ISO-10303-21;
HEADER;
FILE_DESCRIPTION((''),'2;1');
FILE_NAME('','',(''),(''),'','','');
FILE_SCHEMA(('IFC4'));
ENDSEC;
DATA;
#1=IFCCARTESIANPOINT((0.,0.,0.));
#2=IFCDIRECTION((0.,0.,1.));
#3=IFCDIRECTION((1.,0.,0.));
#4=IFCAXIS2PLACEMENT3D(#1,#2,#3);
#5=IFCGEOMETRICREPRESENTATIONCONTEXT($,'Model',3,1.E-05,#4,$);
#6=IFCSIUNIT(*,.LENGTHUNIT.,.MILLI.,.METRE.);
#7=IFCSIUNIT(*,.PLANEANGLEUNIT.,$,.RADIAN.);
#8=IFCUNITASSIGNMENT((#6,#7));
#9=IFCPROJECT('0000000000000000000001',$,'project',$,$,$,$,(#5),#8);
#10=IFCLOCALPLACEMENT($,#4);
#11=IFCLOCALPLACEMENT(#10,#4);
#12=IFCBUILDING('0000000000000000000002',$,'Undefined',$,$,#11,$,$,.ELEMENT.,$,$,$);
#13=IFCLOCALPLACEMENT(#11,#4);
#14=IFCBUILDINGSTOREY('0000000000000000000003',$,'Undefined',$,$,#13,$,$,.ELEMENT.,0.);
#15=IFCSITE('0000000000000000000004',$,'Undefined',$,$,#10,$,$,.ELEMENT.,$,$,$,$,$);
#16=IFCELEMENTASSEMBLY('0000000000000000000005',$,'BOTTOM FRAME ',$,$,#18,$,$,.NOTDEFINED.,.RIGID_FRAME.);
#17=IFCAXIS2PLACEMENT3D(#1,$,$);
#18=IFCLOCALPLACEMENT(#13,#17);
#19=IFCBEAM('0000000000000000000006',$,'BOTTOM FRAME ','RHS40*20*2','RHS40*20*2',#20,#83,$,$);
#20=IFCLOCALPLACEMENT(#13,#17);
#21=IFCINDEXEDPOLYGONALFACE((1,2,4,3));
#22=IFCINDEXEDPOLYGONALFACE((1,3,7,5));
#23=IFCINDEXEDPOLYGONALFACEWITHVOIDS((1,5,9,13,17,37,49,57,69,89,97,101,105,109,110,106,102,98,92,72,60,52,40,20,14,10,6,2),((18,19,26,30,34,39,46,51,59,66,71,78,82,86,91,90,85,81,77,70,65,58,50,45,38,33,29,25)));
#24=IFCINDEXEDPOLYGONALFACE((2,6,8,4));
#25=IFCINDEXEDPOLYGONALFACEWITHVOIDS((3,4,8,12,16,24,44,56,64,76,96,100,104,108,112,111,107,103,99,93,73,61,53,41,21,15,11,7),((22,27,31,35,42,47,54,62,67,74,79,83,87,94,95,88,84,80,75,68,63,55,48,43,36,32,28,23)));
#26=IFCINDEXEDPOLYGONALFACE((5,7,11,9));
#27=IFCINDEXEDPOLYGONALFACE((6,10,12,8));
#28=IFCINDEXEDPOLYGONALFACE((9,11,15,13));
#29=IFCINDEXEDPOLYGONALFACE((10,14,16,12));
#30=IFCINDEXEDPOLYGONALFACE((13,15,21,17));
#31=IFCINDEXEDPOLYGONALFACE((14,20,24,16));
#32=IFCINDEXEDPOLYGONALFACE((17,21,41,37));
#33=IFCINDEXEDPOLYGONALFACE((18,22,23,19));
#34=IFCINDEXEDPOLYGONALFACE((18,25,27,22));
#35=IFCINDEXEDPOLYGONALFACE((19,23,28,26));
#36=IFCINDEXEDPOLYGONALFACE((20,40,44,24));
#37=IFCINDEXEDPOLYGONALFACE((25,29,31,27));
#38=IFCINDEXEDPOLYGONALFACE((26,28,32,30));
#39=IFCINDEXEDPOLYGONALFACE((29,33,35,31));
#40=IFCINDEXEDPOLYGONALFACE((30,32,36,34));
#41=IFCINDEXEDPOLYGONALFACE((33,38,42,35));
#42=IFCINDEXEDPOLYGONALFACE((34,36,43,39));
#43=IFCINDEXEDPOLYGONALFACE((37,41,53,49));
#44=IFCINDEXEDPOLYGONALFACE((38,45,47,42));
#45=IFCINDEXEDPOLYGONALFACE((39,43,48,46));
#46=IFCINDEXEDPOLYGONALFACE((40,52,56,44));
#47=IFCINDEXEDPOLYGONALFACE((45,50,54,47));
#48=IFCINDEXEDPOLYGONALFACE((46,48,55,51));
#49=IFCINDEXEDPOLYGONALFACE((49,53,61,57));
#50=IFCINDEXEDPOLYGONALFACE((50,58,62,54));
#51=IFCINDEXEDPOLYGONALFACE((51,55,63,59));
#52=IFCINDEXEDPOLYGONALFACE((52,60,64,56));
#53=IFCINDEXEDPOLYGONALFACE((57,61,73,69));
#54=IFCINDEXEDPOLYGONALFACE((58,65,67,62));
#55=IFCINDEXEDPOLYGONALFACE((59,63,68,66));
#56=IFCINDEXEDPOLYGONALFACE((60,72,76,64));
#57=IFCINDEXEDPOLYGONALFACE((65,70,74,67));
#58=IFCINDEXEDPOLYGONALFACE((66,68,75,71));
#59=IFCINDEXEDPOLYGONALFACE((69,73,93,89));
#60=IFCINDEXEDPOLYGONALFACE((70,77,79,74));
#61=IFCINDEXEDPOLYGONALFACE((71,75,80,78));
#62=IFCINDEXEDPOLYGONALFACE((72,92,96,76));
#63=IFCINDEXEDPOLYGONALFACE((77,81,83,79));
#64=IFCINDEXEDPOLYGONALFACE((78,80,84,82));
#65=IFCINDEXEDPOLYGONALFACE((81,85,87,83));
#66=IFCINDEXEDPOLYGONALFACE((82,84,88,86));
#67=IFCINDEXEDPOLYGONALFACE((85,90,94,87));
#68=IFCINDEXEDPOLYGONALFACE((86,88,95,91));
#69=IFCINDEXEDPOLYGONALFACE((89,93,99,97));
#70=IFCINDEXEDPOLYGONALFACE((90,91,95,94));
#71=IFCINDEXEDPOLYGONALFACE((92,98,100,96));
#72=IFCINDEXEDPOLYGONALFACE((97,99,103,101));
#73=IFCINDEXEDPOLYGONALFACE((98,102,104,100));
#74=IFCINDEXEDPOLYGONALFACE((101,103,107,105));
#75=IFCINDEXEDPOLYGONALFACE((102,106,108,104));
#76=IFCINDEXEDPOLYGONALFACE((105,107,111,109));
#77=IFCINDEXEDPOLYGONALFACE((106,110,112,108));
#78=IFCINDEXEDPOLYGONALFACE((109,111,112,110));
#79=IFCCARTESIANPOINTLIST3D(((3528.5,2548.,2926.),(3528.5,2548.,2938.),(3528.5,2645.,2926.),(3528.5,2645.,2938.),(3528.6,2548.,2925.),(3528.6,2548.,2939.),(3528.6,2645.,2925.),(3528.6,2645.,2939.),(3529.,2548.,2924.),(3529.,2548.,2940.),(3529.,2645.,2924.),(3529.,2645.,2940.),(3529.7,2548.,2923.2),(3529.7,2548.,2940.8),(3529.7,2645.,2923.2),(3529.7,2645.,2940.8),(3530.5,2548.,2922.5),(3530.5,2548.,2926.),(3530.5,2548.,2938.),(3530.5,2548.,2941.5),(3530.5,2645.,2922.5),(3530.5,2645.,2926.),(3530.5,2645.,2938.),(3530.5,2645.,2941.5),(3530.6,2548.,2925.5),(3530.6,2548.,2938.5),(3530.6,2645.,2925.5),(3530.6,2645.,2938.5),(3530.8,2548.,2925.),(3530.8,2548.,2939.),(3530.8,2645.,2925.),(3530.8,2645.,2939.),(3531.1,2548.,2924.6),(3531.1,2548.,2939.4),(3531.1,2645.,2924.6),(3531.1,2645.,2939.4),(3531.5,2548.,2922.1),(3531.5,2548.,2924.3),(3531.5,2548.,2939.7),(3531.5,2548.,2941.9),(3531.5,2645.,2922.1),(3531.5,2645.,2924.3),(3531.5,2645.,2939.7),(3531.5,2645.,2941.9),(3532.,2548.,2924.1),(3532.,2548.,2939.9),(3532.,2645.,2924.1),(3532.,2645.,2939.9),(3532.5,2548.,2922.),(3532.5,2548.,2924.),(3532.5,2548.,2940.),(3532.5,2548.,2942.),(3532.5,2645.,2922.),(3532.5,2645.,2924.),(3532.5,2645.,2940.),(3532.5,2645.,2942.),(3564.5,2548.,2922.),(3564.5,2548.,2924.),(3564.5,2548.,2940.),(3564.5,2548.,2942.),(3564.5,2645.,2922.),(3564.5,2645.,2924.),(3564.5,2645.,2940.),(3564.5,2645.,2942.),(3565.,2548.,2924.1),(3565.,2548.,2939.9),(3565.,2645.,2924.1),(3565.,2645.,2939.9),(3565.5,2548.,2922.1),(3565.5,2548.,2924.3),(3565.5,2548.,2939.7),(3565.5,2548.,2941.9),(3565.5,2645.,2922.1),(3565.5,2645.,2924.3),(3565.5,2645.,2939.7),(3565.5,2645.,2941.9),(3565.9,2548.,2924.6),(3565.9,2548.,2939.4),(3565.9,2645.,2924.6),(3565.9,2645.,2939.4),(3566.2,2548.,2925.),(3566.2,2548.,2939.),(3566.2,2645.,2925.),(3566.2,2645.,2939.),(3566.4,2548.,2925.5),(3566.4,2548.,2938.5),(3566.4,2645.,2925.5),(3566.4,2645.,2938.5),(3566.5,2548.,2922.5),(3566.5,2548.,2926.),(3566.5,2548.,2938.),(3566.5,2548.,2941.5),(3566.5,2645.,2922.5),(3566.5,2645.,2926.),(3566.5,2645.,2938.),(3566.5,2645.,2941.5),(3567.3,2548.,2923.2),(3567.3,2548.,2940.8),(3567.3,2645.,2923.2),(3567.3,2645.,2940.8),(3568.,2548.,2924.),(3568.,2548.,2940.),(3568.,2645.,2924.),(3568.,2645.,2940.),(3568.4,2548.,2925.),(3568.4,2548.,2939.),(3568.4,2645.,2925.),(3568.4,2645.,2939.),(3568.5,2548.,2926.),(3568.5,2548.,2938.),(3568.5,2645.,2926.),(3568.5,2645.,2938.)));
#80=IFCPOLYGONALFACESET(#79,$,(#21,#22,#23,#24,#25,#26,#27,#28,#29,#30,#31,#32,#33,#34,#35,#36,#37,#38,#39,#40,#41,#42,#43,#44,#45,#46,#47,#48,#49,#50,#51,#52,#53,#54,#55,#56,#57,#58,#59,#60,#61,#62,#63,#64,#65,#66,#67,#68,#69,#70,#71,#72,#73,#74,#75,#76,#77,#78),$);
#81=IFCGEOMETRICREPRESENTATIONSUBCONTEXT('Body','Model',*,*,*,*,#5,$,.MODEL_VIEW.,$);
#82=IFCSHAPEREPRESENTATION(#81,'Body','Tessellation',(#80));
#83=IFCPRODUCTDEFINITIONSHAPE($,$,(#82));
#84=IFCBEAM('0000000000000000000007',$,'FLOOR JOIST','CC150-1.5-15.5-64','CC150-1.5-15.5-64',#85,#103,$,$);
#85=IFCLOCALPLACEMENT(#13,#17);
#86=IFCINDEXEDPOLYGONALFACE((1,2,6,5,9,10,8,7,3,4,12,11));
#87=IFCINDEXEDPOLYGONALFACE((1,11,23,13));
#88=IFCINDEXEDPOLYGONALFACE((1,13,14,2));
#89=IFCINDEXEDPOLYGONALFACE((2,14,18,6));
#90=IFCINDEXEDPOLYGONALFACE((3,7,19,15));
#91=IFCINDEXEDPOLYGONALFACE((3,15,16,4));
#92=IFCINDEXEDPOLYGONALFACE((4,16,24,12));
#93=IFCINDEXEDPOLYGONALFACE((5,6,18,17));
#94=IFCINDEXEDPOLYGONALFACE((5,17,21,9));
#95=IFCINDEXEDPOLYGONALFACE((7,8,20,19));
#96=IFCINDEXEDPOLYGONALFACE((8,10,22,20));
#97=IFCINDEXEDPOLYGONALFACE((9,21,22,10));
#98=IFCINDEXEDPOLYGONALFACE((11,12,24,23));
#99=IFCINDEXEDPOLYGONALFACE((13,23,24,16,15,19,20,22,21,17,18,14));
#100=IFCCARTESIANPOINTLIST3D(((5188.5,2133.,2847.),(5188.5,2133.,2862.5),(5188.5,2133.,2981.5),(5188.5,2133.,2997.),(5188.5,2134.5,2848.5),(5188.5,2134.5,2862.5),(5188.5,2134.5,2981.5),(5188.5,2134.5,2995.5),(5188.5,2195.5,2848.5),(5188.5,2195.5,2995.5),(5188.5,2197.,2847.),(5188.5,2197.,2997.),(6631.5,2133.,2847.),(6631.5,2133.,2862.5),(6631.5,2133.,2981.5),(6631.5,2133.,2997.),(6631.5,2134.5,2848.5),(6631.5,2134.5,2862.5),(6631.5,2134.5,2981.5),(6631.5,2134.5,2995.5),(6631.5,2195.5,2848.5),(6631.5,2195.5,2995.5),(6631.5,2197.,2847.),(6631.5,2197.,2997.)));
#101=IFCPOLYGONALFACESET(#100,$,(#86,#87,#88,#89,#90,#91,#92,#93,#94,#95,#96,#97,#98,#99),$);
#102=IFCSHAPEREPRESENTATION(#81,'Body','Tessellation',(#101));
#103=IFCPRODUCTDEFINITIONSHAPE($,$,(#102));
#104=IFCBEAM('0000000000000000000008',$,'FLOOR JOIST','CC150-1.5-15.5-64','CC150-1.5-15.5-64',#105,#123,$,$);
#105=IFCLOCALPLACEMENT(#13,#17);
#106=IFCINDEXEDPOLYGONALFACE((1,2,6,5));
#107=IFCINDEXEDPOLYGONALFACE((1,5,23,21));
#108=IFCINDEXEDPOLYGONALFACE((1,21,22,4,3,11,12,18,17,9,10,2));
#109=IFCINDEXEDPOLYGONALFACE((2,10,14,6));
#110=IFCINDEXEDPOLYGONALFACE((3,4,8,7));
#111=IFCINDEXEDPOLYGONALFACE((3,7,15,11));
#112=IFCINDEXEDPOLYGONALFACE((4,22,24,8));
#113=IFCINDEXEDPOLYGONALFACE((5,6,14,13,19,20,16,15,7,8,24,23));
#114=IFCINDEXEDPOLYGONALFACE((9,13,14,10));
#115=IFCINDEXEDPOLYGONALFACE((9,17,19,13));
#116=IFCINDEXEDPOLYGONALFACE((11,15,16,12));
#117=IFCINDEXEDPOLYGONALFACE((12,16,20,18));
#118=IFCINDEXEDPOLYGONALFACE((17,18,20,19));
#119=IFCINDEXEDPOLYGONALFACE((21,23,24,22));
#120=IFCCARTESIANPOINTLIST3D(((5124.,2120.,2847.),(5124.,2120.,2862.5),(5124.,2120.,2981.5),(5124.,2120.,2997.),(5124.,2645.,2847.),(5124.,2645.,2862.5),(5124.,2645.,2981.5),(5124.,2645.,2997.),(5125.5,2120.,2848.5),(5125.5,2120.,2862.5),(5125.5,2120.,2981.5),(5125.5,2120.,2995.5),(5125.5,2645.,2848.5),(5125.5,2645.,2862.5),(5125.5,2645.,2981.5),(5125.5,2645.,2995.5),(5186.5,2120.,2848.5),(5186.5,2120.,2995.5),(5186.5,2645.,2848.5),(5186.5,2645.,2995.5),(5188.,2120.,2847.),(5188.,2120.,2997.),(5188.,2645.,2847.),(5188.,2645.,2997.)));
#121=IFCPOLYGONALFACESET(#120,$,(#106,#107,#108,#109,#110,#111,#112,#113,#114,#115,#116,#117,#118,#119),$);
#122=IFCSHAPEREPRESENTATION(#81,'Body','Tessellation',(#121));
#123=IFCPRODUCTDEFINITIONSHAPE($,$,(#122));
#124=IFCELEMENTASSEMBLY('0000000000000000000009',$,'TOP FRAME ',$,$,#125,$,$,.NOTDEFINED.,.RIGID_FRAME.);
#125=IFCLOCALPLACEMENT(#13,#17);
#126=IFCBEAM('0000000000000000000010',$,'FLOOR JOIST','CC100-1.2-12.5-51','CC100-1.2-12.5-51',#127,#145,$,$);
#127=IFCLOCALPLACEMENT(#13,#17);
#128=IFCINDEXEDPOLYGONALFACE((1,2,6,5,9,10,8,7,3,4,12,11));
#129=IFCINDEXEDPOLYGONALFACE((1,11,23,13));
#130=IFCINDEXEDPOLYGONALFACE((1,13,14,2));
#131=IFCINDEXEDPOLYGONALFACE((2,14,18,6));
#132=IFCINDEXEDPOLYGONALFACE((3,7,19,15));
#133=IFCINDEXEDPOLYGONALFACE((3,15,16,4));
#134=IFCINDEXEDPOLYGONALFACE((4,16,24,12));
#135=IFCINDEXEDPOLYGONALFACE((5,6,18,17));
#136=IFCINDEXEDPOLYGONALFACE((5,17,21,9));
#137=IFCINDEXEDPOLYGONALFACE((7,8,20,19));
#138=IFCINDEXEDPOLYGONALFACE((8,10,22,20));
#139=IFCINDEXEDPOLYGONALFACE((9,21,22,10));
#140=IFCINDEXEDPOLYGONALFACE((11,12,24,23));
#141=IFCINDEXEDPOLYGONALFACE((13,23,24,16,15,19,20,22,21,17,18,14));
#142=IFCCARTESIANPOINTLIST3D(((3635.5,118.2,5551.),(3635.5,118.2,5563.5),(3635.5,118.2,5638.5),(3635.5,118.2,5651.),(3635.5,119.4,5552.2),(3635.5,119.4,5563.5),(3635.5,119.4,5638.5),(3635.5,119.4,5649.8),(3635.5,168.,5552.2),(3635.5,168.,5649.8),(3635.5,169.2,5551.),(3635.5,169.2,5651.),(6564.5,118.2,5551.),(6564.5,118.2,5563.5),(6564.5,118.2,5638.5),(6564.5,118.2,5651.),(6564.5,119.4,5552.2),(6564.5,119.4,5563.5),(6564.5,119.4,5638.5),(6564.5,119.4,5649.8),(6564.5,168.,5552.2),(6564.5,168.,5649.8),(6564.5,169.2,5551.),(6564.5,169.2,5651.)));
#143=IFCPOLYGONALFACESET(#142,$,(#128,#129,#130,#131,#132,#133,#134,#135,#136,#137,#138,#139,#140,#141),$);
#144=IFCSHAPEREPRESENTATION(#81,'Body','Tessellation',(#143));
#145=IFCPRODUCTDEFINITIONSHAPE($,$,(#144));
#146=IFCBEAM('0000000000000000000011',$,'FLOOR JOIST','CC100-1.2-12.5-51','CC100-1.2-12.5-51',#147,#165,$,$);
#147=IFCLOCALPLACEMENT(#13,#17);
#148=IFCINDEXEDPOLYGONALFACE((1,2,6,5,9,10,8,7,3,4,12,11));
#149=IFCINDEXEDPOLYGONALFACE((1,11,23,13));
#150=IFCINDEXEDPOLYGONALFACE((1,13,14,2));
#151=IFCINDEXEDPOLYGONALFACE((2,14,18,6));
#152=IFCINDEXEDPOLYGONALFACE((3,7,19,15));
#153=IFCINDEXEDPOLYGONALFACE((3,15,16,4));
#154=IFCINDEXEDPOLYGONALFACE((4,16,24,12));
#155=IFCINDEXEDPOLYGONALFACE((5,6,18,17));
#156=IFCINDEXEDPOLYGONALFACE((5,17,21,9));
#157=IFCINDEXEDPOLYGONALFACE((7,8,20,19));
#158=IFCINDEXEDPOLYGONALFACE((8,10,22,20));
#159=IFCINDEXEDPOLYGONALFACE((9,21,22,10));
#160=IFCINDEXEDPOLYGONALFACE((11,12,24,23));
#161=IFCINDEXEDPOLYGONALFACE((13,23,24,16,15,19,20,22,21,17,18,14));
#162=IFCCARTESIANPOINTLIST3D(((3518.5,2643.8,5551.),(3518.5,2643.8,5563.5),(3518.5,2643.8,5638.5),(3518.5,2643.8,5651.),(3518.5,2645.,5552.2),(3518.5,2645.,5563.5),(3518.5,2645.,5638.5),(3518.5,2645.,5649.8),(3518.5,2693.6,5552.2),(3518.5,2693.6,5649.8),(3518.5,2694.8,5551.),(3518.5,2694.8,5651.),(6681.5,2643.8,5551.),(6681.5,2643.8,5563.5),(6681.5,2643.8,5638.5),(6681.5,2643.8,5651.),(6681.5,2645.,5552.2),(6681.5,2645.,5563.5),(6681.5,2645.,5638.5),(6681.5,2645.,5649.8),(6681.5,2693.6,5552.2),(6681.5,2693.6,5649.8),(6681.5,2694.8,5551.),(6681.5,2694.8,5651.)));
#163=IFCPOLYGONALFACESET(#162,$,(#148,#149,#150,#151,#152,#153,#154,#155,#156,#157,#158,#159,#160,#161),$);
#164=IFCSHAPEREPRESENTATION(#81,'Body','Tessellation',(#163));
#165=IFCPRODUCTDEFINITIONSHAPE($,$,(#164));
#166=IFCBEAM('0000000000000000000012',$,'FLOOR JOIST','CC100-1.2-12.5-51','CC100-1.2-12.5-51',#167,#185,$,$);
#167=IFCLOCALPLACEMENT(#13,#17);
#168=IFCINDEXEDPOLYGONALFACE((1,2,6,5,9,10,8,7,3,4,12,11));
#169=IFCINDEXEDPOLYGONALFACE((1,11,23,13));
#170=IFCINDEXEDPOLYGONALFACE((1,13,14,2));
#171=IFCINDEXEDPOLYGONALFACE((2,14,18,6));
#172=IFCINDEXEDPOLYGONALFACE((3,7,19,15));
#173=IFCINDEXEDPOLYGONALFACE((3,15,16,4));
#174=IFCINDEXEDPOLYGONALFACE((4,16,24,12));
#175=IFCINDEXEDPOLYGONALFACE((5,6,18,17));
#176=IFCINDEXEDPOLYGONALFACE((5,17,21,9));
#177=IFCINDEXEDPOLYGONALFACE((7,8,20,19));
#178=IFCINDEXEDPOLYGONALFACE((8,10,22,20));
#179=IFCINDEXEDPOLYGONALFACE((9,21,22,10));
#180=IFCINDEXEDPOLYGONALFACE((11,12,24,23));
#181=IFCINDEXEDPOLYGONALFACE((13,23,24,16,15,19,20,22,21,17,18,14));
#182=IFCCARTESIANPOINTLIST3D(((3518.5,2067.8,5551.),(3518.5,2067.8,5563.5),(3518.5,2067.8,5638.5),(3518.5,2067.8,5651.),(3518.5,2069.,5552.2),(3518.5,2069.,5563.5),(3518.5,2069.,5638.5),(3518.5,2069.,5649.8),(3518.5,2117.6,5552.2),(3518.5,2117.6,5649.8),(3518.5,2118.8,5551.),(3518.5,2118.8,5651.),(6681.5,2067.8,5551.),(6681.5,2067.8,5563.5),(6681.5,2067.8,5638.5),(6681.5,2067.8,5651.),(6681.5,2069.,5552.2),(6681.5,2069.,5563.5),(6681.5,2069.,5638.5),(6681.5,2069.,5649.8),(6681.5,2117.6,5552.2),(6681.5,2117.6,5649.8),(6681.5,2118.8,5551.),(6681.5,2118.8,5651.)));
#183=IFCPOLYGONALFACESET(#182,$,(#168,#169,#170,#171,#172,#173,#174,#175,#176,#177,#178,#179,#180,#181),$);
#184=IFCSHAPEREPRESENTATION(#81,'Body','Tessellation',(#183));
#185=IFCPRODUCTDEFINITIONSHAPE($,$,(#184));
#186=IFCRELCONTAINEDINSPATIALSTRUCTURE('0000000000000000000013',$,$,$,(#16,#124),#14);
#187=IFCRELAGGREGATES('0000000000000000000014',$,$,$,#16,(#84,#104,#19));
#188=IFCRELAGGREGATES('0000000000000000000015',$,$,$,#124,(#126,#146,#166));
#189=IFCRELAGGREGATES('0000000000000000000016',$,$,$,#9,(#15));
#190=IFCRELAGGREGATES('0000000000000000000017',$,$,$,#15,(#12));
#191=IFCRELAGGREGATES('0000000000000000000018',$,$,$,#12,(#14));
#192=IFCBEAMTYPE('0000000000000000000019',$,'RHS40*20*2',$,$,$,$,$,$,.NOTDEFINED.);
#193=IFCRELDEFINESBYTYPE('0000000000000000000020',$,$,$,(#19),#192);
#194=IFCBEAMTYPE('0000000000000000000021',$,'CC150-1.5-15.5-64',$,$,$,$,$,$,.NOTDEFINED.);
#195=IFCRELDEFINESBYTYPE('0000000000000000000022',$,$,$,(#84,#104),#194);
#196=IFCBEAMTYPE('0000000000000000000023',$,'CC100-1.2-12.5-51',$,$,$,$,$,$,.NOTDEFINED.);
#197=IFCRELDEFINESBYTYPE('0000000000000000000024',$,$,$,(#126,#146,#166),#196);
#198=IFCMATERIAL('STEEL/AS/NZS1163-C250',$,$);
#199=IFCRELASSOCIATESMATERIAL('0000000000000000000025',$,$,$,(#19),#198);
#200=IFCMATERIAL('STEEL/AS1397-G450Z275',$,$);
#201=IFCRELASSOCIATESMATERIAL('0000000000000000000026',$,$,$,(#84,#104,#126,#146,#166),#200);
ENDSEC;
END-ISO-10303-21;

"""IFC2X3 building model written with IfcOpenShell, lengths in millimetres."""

from ifc_helpers import new_model, si_unit, frame, origin_with_axes, origin_2d_with_axis, place, context, subcontext, project, spatial, hollow_rectangle, c_section, extrude, material, type_object, element, aggregate, save


model = new_model("IFC2X3")

# Units and contexts
model_context = context("Model", 3, precision=1e-05, world=origin_with_axes())
body_context = subcontext(model_context, "Body", "Model", "MODEL_VIEW")
ifc_project = project(units=[si_unit("LENGTHUNIT", "METRE", prefix="MILLI"), si_unit("PLANEANGLEUNIT", "RADIAN")], contexts=[model_context])

# Site, building, storey
site_placement = place(None, origin_with_axes())
site = spatial("IfcSite", under=ifc_project, at=site_placement, Name="Undefined", CompositionType="ELEMENT")
building_placement = place(site_placement, origin_with_axes())
building = spatial("IfcBuilding", under=site, at=building_placement, Name="Undefined", CompositionType="ELEMENT")
storey_placement = place(building_placement, origin_with_axes())
storey = spatial("IfcBuildingStorey", under=building, at=storey_placement, Name="Undefined", CompositionType="ELEMENT", Elevation=0.0)

# Element assemblies, beams
assembly_1_placement = place(storey_placement, origin_with_axes())
assembly_1 = element("IfcElementAssembly", 1, at=assembly_1_placement, inside=storey, Name="BOTTOM FRAME ", AssemblyPlace="NOTDEFINED", PredefinedType="RIGID_FRAME")
ifc_material_1 = material(Name="STEEL/AS1397-G450Z275")
ifc_material_2 = material(Name="STEEL/AS/NZS1163-C250")
beam_type_1 = type_object("IfcBeamType", Name="RHS40*20*2", PredefinedType="NOTDEFINED")
beam_1_placement = place(assembly_1_placement, frame((3548.5, 2645.0, 2932.0), z_axis=(1.0, 0.0, 0.0), x_axis=(0.0, -1.0, 0.0)))
beam_1 = element("IfcBeam", 2, at=beam_1_placement, type_object=beam_type_1, material=ifc_material_2, Name="BOTTOM FRAME ", Description="RHS40*20*2", ObjectType="RHS40*20*2", context=body_context, shape_type="SweptSolid", body=[
    extrude(hollow_rectangle(XDim=20.0, YDim=40.0, WallThickness=2.0, InnerFilletRadius=2.0, OuterFilletRadius=4.0, at=origin_2d_with_axis()), frame((97.0, 0.0, 0.0), z_axis=(-1.0, 0.0, 0.0), x_axis=(0.0, -1.0, 0.0)), (0.0, 0.0, 1.0), 97.0),
])
beam_type_2 = type_object("IfcBeamType", Name="CC150-1.5-15.5-64", PredefinedType="NOTDEFINED")
beam_2_placement = place(assembly_1_placement, frame((5188.5, 2165.0, 2922.0), z_axis=(0.0, 0.0, 1.0), x_axis=(1.0, 0.0, 0.0)))
beam_2 = element("IfcBeam", 3, at=beam_2_placement, type_object=beam_type_2, material=ifc_material_1, Name="FLOOR JOIST", Description="CC150-1.5-15.5-64", ObjectType="CC150-1.5-15.5-64", context=body_context, shape_type="SweptSolid", body=[
    extrude(c_section(Depth=150.0, Width=64.0, WallThickness=1.5, Girth=15.5, at=origin_2d_with_axis()), frame((1443.0, 0.0, 0.0), z_axis=(-1.0, 0.0, 0.0), x_axis=(0.0, -1.0, 0.0)), (0.0, 0.0, 1.0), 1443.0),
])
beam_3_placement = place(assembly_1_placement, frame((5156.0, 2645.0, 2922.0), z_axis=(0.0, 0.0, 1.0), x_axis=(0.0, -1.0, 0.0)))
beam_3 = element("IfcBeam", 4, at=beam_3_placement, type_object=beam_type_2, material=ifc_material_1, Name="FLOOR JOIST", Description="CC150-1.5-15.5-64", ObjectType="CC150-1.5-15.5-64", context=body_context, shape_type="SweptSolid", body=[
    extrude(c_section(Depth=150.0, Width=64.0, WallThickness=1.5, Girth=15.5, at=origin_2d_with_axis()), frame((525.0, 0.0, 0.0), z_axis=(-1.0, 0.0, 0.0), x_axis=(0.0, -1.0, 0.0)), (0.0, 0.0, 1.0), 525.0),
])
assembly_2_placement = place(storey_placement, origin_with_axes())
assembly_2 = element("IfcElementAssembly", 5, at=assembly_2_placement, inside=storey, Name="TOP FRAME ", AssemblyPlace="NOTDEFINED", PredefinedType="RIGID_FRAME")
beam_type_3 = type_object("IfcBeamType", Name="CC100-1.2-12.5-51", PredefinedType="NOTDEFINED")
beam_4_placement = place(assembly_2_placement, frame((3635.5, 143.7, 5601.0), z_axis=(0.0, 0.0, 1.0), x_axis=(1.0, 0.0, 0.0)))
beam_4 = element("IfcBeam", 6, at=beam_4_placement, type_object=beam_type_3, material=ifc_material_1, Name="FLOOR JOIST", Description="CC100-1.2-12.5-51", ObjectType="CC100-1.2-12.5-51", context=body_context, shape_type="SweptSolid", body=[
    extrude(c_section(Depth=100.0, Width=51.0, WallThickness=1.2, Girth=12.5, at=origin_2d_with_axis()), frame((2929.0, 0.0, 0.0), z_axis=(-1.0, 0.0, 0.0), x_axis=(0.0, -1.0, 0.0)), (0.0, 0.0, 1.0), 2929.0),
])
beam_5_placement = place(assembly_2_placement, frame((3518.5, 2669.3, 5601.0), z_axis=(0.0, 0.0, 1.0), x_axis=(1.0, 0.0, 0.0)))
beam_5 = element("IfcBeam", 7, at=beam_5_placement, type_object=beam_type_3, material=ifc_material_1, Name="FLOOR JOIST", Description="CC100-1.2-12.5-51", ObjectType="CC100-1.2-12.5-51", context=body_context, shape_type="SweptSolid", body=[
    extrude(c_section(Depth=100.0, Width=51.0, WallThickness=1.2, Girth=12.5, at=origin_2d_with_axis()), frame((3163.0, 0.0, 0.0), z_axis=(-1.0, 0.0, 0.0), x_axis=(0.0, -1.0, 0.0)), (0.0, 0.0, 1.0), 3163.0),
])
beam_6_placement = place(assembly_2_placement, frame((3518.5, 2093.3, 5601.0), z_axis=(0.0, 0.0, 1.0), x_axis=(1.0, 0.0, 0.0)))
beam_6 = element("IfcBeam", 8, at=beam_6_placement, type_object=beam_type_3, material=ifc_material_1, Name="FLOOR JOIST", Description="CC100-1.2-12.5-51", ObjectType="CC100-1.2-12.5-51", context=body_context, shape_type="SweptSolid", body=[
    extrude(c_section(Depth=100.0, Width=51.0, WallThickness=1.2, Girth=12.5, at=origin_2d_with_axis()), frame((3163.0, 0.0, 0.0), z_axis=(-1.0, 0.0, 0.0), x_axis=(0.0, -1.0, 0.0)), (0.0, 0.0, 1.0), 3163.0),
])

aggregate(assembly_1, [beam_2, beam_3, beam_1])

aggregate(assembly_2, [beam_4, beam_5, beam_6])

save(model, "model.ifc")
